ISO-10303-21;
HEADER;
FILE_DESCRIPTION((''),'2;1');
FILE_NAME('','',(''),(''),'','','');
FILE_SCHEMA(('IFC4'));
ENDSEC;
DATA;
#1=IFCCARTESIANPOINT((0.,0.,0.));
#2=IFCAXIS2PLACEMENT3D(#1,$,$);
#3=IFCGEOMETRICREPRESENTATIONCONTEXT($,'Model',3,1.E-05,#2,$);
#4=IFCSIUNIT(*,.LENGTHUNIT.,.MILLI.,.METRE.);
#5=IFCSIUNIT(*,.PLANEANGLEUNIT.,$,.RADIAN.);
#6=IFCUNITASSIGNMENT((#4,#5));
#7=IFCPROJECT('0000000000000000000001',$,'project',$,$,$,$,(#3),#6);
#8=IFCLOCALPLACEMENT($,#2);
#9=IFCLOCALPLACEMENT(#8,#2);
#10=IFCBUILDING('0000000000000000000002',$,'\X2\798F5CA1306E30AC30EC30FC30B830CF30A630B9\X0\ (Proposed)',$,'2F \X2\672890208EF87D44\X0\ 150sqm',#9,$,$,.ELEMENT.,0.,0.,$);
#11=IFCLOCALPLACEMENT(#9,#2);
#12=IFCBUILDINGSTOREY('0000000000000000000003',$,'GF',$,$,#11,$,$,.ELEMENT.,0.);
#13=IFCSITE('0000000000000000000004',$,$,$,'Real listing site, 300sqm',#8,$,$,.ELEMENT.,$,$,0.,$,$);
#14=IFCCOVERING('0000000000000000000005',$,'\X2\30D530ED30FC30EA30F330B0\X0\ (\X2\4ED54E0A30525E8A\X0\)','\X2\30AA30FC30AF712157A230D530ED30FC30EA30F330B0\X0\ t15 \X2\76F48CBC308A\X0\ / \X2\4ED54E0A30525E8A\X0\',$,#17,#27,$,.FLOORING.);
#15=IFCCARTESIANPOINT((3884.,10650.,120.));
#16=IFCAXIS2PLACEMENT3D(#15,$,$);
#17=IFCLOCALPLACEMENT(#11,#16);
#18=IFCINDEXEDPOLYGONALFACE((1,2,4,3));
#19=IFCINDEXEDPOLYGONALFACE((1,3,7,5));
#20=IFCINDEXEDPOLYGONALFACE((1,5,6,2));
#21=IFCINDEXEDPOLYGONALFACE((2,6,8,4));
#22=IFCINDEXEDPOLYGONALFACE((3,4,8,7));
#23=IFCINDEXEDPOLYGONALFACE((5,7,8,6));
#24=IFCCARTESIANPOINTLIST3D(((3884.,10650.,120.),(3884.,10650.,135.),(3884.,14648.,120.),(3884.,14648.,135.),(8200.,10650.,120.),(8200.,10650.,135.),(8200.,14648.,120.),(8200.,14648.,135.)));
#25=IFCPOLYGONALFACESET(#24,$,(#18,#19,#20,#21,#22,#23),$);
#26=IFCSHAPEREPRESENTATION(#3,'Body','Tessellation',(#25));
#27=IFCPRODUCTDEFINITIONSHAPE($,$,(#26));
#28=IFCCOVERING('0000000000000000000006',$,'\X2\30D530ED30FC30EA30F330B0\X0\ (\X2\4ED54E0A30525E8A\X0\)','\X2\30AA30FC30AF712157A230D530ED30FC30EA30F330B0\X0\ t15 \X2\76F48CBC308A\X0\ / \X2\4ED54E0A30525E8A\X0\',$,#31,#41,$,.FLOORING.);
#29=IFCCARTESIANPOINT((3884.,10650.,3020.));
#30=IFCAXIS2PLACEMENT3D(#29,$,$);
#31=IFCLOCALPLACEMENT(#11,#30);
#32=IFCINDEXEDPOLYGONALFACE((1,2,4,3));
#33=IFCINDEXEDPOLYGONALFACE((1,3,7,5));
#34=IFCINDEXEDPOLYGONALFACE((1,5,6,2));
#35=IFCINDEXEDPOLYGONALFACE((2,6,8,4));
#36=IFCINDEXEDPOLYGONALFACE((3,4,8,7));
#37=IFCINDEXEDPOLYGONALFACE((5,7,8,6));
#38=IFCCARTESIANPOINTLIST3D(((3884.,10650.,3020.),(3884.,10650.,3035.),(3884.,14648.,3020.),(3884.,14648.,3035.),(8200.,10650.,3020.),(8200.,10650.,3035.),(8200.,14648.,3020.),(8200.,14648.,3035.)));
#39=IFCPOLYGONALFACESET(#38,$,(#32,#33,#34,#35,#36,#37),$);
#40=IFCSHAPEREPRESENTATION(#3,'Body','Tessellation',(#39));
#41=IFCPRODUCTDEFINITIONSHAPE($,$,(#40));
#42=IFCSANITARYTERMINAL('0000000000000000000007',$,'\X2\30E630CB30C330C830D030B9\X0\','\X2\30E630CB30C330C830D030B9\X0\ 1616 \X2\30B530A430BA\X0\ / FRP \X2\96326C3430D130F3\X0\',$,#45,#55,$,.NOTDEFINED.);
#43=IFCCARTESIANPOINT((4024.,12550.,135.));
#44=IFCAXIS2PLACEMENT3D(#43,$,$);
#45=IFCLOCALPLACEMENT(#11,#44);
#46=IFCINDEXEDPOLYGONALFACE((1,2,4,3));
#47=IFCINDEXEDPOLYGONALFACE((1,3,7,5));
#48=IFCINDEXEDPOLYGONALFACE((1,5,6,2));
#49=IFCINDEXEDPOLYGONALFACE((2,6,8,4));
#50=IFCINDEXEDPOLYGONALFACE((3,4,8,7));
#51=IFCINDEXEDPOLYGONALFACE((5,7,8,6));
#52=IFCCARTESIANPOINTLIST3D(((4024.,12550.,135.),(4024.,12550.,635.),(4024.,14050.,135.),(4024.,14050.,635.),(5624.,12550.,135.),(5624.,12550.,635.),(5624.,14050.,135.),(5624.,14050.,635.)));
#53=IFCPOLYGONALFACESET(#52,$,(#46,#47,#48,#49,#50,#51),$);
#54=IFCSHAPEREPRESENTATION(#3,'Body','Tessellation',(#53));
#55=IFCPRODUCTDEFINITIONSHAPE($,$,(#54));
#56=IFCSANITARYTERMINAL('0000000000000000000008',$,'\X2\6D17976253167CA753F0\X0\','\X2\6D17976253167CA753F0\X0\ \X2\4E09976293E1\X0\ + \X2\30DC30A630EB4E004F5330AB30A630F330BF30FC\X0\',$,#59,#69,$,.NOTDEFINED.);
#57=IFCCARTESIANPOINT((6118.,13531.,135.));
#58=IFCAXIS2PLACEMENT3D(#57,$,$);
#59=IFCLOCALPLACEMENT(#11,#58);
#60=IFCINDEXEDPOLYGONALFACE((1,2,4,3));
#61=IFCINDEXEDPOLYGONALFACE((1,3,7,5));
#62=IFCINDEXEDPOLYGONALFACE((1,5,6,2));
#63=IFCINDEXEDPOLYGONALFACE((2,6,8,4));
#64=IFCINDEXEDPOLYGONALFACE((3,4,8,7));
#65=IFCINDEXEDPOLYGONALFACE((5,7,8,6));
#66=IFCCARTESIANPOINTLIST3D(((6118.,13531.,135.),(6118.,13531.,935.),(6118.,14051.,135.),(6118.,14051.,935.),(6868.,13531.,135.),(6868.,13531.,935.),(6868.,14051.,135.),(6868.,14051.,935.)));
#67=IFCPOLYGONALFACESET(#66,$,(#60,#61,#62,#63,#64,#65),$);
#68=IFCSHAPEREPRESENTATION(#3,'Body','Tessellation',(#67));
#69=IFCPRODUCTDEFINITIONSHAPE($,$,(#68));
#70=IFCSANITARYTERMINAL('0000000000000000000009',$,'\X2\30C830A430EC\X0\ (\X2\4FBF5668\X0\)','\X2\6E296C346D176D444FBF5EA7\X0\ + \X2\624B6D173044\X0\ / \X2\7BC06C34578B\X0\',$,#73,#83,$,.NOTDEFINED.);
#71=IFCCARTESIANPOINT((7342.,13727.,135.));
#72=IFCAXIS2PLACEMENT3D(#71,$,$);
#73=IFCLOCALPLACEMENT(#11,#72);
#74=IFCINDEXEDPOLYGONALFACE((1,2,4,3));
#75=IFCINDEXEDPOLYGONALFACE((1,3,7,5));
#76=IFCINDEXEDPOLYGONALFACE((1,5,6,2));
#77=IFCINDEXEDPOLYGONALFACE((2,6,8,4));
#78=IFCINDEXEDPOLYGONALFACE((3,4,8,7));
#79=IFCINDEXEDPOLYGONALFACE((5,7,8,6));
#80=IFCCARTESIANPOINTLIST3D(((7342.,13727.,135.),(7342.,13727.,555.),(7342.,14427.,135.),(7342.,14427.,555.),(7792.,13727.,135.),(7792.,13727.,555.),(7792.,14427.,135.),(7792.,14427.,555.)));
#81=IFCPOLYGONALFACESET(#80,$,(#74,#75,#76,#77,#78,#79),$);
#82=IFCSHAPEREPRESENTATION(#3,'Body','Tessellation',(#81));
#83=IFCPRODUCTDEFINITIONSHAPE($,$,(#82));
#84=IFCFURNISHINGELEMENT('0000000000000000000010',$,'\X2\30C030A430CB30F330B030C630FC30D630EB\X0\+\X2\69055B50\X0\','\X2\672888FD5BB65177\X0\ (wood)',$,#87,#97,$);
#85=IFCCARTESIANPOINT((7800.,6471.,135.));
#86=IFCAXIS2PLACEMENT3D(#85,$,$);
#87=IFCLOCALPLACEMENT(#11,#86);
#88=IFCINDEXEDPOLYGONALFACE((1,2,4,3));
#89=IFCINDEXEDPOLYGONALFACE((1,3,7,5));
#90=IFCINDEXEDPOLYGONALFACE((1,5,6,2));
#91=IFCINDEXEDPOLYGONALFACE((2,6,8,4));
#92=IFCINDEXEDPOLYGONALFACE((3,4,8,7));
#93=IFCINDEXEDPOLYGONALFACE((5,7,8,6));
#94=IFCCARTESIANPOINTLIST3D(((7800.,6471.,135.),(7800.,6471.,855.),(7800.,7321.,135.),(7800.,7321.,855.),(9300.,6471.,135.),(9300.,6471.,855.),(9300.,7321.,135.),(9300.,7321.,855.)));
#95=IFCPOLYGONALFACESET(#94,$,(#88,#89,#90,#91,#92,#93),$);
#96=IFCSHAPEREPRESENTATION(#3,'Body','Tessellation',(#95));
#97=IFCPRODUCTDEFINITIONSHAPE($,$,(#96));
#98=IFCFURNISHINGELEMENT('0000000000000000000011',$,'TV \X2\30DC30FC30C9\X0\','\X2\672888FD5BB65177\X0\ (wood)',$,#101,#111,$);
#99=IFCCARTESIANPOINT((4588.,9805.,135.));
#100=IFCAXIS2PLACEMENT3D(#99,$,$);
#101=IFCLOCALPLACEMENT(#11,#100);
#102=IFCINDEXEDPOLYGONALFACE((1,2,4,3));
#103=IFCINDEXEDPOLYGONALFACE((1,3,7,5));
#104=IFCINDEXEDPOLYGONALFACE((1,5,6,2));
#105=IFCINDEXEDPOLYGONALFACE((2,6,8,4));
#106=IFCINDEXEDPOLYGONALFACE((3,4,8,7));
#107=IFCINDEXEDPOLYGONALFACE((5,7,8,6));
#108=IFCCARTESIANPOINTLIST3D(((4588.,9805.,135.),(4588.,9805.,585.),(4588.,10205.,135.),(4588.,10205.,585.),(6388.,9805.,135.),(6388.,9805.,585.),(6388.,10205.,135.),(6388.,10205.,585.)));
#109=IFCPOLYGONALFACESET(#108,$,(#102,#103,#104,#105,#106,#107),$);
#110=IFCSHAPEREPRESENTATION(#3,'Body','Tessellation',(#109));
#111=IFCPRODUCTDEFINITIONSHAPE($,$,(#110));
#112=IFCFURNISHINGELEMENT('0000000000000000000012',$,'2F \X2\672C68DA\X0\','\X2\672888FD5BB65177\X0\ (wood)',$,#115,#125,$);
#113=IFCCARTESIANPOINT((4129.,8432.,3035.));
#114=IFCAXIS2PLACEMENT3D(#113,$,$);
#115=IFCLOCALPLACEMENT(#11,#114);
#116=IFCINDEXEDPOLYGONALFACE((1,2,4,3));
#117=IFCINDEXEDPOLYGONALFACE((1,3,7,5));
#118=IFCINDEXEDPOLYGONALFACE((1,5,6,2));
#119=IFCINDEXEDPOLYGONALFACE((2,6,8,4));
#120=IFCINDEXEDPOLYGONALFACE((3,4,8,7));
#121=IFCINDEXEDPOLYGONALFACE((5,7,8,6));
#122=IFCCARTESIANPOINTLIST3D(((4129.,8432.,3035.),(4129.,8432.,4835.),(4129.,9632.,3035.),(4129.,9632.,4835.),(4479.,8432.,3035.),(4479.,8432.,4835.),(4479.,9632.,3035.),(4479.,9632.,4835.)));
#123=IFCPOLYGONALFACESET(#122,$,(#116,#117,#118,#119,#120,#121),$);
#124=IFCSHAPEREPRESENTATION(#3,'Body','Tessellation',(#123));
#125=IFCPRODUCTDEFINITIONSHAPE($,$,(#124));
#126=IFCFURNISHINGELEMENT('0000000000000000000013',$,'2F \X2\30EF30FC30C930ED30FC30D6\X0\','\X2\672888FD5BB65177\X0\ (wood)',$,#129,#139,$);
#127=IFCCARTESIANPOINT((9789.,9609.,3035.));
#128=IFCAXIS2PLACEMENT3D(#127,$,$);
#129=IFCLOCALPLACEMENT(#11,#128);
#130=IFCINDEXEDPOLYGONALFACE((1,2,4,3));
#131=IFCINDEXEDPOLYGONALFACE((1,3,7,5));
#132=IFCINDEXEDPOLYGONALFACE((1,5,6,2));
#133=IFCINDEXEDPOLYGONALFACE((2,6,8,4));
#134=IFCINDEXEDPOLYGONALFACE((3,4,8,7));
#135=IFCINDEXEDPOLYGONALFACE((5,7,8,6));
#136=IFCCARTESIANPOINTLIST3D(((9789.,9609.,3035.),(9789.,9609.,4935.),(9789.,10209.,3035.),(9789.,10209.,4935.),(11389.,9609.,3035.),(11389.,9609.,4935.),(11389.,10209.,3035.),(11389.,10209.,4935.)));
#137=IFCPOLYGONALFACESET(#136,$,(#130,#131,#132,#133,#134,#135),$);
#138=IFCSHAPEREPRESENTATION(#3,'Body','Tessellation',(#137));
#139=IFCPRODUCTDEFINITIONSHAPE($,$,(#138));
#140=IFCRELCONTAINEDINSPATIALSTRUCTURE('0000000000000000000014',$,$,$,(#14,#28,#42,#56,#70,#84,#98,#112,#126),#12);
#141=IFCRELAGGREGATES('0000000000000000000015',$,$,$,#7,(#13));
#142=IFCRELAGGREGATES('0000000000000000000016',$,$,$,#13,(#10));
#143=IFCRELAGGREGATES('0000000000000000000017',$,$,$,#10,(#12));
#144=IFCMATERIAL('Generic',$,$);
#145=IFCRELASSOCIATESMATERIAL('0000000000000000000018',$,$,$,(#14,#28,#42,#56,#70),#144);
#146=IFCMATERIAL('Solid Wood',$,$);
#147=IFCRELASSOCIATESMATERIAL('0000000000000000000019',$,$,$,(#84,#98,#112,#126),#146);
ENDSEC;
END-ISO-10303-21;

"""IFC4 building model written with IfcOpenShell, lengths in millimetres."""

from ifc_helpers import new_model, si_unit, frame, frame_2d, origin, place, context, project, spatial, rectangle, extrude, material, element, save


model = new_model("IFC4")

# Units and contexts
model_context = context("Model", 3, precision=1e-05, world=origin())
ifc_project = project(units=[si_unit("LENGTHUNIT", "METRE", prefix="MILLI"), si_unit("PLANEANGLEUNIT", "RADIAN")], contexts=[model_context])

# Site, building, storey
site_placement = place(None, origin())
site = spatial("IfcSite", under=ifc_project, at=site_placement, ObjectType="Real listing site, 300sqm", CompositionType="ELEMENT", RefElevation=0.0)
building_placement = place(site_placement, origin())
building = spatial("IfcBuilding", under=site, at=building_placement, Name="福岡のガレージハウス (Proposed)", ObjectType="2F 木造軸組 150sqm", CompositionType="ELEMENT", ElevationOfRefHeight=0.0, ElevationOfTerrain=0.0)
storey_placement = place(building_placement, origin())
storey = spatial("IfcBuildingStorey", under=building, at=storey_placement, Name="GF", CompositionType="ELEMENT", Elevation=0.0)

# Shared definitions
ifc_material_1 = material(Name="Solid Wood")

# Coverings
ifc_material_2 = material(Name="Generic")
covering_1_placement = place(storey_placement, frame((3884.0, 10650.0, 120.0)))
element("IfcCovering", 1, at=covering_1_placement, inside=storey, material=ifc_material_2, Name="フローリング (仕上げ床)", Description="オーク無垢フローリング t15 直貼り / 仕上げ床", PredefinedType="FLOORING", context=model_context, shape_type="SweptSolid", body=[
    extrude(rectangle(XDim=4316.0, YDim=3998.0, at=frame_2d((2158.0, 1999.0))), frame((3884.0, 10650.0, 120.0)), (0.0, 0.0, 1.0), 15.0),
])
covering_2_placement = place(storey_placement, frame((3884.0, 10650.0, 3020.0)))
element("IfcCovering", 2, at=covering_2_placement, inside=storey, material=ifc_material_2, Name="フローリング (仕上げ床)", Description="オーク無垢フローリング t15 直貼り / 仕上げ床", PredefinedType="FLOORING", context=model_context, shape_type="SweptSolid", body=[
    extrude(rectangle(XDim=4316.0, YDim=3998.0, at=frame_2d((2158.0, 1999.0))), frame((3884.0, 10650.0, 3020.0)), (0.0, 0.0, 1.0), 15.0),
])

# Sanitary terminals
sanitary_terminal_1_placement = place(storey_placement, frame((4024.0, 12550.0, 135.0)))
element("IfcSanitaryTerminal", 3, at=sanitary_terminal_1_placement, inside=storey, material=ifc_material_2, Name="ユニットバス", Description="ユニットバス 1616 サイズ / FRP 防水パン", PredefinedType="NOTDEFINED", context=model_context, shape_type="SweptSolid", body=[
    extrude(rectangle(XDim=1600.0, YDim=1500.0, at=frame_2d((800.0, 750.0))), frame((4024.0, 12550.0, 135.0)), (0.0, 0.0, 1.0), 500.0),
])
sanitary_terminal_2_placement = place(storey_placement, frame((6118.0, 13531.0, 135.0)))
element("IfcSanitaryTerminal", 4, at=sanitary_terminal_2_placement, inside=storey, material=ifc_material_2, Name="洗面化粧台", Description="洗面化粧台 三面鏡 + ボウル一体カウンター", PredefinedType="NOTDEFINED", context=model_context, shape_type="SweptSolid", body=[
    extrude(rectangle(XDim=750.0, YDim=520.0, at=frame_2d((375.0, 260.0))), frame((6118.0, 13531.0, 135.0)), (0.0, 0.0, 1.0), 800.0),
])
sanitary_terminal_3_placement = place(storey_placement, frame((7342.0, 13727.0, 135.0)))
element("IfcSanitaryTerminal", 5, at=sanitary_terminal_3_placement, inside=storey, material=ifc_material_2, Name="トイレ (便器)", Description="温水洗浄便座 + 手洗い / 節水型", PredefinedType="NOTDEFINED", context=model_context, shape_type="SweptSolid", body=[
    extrude(rectangle(XDim=450.0, YDim=700.0, at=frame_2d((225.0, 350.0))), frame((7342.0, 13727.0, 135.0)), (0.0, 0.0, 1.0), 420.0),
])

# Furnishing elements
furnishing_1_placement = place(storey_placement, frame((7800.0, 6471.0, 135.0)))
element("IfcFurnishingElement", 6, at=furnishing_1_placement, inside=storey, material=ifc_material_1, Name="ダイニングテーブル+椅子", Description="木製家具 (wood)", context=model_context, shape_type="SweptSolid", body=[
    extrude(rectangle(XDim=1500.0, YDim=850.0, at=frame_2d((750.0, 425.0))), frame((7800.0, 6471.0, 135.0)), (0.0, 0.0, 1.0), 720.0),
])
furnishing_2_placement = place(storey_placement, frame((4588.0, 9805.0, 135.0)))
element("IfcFurnishingElement", 7, at=furnishing_2_placement, inside=storey, material=ifc_material_1, Name="TV ボード", Description="木製家具 (wood)", context=model_context, shape_type="SweptSolid", body=[
    extrude(rectangle(XDim=1800.0, YDim=400.0, at=frame_2d((900.0, 200.0))), frame((4588.0, 9805.0, 135.0)), (0.0, 0.0, 1.0), 450.0),
])
furnishing_3_placement = place(storey_placement, frame((4129.0, 8432.0, 3035.0)))
element("IfcFurnishingElement", 8, at=furnishing_3_placement, inside=storey, material=ifc_material_1, Name="2F 本棚", Description="木製家具 (wood)", context=model_context, shape_type="SweptSolid", body=[
    extrude(rectangle(XDim=350.0, YDim=1200.0, at=frame_2d((175.0, 600.0))), frame((4129.0, 8432.0, 3035.0)), (0.0, 0.0, 1.0), 1800.0),
])
furnishing_4_placement = place(storey_placement, frame((9789.0, 9609.0, 3035.0)))
element("IfcFurnishingElement", 9, at=furnishing_4_placement, inside=storey, material=ifc_material_1, Name="2F ワードローブ", Description="木製家具 (wood)", context=model_context, shape_type="SweptSolid", body=[
    extrude(rectangle(XDim=1600.0, YDim=600.0, at=frame_2d((800.0, 300.0))), frame((9789.0, 9609.0, 3035.0)), (0.0, 0.0, 1.0), 1900.0),
])

save(model, "model.ifc")
